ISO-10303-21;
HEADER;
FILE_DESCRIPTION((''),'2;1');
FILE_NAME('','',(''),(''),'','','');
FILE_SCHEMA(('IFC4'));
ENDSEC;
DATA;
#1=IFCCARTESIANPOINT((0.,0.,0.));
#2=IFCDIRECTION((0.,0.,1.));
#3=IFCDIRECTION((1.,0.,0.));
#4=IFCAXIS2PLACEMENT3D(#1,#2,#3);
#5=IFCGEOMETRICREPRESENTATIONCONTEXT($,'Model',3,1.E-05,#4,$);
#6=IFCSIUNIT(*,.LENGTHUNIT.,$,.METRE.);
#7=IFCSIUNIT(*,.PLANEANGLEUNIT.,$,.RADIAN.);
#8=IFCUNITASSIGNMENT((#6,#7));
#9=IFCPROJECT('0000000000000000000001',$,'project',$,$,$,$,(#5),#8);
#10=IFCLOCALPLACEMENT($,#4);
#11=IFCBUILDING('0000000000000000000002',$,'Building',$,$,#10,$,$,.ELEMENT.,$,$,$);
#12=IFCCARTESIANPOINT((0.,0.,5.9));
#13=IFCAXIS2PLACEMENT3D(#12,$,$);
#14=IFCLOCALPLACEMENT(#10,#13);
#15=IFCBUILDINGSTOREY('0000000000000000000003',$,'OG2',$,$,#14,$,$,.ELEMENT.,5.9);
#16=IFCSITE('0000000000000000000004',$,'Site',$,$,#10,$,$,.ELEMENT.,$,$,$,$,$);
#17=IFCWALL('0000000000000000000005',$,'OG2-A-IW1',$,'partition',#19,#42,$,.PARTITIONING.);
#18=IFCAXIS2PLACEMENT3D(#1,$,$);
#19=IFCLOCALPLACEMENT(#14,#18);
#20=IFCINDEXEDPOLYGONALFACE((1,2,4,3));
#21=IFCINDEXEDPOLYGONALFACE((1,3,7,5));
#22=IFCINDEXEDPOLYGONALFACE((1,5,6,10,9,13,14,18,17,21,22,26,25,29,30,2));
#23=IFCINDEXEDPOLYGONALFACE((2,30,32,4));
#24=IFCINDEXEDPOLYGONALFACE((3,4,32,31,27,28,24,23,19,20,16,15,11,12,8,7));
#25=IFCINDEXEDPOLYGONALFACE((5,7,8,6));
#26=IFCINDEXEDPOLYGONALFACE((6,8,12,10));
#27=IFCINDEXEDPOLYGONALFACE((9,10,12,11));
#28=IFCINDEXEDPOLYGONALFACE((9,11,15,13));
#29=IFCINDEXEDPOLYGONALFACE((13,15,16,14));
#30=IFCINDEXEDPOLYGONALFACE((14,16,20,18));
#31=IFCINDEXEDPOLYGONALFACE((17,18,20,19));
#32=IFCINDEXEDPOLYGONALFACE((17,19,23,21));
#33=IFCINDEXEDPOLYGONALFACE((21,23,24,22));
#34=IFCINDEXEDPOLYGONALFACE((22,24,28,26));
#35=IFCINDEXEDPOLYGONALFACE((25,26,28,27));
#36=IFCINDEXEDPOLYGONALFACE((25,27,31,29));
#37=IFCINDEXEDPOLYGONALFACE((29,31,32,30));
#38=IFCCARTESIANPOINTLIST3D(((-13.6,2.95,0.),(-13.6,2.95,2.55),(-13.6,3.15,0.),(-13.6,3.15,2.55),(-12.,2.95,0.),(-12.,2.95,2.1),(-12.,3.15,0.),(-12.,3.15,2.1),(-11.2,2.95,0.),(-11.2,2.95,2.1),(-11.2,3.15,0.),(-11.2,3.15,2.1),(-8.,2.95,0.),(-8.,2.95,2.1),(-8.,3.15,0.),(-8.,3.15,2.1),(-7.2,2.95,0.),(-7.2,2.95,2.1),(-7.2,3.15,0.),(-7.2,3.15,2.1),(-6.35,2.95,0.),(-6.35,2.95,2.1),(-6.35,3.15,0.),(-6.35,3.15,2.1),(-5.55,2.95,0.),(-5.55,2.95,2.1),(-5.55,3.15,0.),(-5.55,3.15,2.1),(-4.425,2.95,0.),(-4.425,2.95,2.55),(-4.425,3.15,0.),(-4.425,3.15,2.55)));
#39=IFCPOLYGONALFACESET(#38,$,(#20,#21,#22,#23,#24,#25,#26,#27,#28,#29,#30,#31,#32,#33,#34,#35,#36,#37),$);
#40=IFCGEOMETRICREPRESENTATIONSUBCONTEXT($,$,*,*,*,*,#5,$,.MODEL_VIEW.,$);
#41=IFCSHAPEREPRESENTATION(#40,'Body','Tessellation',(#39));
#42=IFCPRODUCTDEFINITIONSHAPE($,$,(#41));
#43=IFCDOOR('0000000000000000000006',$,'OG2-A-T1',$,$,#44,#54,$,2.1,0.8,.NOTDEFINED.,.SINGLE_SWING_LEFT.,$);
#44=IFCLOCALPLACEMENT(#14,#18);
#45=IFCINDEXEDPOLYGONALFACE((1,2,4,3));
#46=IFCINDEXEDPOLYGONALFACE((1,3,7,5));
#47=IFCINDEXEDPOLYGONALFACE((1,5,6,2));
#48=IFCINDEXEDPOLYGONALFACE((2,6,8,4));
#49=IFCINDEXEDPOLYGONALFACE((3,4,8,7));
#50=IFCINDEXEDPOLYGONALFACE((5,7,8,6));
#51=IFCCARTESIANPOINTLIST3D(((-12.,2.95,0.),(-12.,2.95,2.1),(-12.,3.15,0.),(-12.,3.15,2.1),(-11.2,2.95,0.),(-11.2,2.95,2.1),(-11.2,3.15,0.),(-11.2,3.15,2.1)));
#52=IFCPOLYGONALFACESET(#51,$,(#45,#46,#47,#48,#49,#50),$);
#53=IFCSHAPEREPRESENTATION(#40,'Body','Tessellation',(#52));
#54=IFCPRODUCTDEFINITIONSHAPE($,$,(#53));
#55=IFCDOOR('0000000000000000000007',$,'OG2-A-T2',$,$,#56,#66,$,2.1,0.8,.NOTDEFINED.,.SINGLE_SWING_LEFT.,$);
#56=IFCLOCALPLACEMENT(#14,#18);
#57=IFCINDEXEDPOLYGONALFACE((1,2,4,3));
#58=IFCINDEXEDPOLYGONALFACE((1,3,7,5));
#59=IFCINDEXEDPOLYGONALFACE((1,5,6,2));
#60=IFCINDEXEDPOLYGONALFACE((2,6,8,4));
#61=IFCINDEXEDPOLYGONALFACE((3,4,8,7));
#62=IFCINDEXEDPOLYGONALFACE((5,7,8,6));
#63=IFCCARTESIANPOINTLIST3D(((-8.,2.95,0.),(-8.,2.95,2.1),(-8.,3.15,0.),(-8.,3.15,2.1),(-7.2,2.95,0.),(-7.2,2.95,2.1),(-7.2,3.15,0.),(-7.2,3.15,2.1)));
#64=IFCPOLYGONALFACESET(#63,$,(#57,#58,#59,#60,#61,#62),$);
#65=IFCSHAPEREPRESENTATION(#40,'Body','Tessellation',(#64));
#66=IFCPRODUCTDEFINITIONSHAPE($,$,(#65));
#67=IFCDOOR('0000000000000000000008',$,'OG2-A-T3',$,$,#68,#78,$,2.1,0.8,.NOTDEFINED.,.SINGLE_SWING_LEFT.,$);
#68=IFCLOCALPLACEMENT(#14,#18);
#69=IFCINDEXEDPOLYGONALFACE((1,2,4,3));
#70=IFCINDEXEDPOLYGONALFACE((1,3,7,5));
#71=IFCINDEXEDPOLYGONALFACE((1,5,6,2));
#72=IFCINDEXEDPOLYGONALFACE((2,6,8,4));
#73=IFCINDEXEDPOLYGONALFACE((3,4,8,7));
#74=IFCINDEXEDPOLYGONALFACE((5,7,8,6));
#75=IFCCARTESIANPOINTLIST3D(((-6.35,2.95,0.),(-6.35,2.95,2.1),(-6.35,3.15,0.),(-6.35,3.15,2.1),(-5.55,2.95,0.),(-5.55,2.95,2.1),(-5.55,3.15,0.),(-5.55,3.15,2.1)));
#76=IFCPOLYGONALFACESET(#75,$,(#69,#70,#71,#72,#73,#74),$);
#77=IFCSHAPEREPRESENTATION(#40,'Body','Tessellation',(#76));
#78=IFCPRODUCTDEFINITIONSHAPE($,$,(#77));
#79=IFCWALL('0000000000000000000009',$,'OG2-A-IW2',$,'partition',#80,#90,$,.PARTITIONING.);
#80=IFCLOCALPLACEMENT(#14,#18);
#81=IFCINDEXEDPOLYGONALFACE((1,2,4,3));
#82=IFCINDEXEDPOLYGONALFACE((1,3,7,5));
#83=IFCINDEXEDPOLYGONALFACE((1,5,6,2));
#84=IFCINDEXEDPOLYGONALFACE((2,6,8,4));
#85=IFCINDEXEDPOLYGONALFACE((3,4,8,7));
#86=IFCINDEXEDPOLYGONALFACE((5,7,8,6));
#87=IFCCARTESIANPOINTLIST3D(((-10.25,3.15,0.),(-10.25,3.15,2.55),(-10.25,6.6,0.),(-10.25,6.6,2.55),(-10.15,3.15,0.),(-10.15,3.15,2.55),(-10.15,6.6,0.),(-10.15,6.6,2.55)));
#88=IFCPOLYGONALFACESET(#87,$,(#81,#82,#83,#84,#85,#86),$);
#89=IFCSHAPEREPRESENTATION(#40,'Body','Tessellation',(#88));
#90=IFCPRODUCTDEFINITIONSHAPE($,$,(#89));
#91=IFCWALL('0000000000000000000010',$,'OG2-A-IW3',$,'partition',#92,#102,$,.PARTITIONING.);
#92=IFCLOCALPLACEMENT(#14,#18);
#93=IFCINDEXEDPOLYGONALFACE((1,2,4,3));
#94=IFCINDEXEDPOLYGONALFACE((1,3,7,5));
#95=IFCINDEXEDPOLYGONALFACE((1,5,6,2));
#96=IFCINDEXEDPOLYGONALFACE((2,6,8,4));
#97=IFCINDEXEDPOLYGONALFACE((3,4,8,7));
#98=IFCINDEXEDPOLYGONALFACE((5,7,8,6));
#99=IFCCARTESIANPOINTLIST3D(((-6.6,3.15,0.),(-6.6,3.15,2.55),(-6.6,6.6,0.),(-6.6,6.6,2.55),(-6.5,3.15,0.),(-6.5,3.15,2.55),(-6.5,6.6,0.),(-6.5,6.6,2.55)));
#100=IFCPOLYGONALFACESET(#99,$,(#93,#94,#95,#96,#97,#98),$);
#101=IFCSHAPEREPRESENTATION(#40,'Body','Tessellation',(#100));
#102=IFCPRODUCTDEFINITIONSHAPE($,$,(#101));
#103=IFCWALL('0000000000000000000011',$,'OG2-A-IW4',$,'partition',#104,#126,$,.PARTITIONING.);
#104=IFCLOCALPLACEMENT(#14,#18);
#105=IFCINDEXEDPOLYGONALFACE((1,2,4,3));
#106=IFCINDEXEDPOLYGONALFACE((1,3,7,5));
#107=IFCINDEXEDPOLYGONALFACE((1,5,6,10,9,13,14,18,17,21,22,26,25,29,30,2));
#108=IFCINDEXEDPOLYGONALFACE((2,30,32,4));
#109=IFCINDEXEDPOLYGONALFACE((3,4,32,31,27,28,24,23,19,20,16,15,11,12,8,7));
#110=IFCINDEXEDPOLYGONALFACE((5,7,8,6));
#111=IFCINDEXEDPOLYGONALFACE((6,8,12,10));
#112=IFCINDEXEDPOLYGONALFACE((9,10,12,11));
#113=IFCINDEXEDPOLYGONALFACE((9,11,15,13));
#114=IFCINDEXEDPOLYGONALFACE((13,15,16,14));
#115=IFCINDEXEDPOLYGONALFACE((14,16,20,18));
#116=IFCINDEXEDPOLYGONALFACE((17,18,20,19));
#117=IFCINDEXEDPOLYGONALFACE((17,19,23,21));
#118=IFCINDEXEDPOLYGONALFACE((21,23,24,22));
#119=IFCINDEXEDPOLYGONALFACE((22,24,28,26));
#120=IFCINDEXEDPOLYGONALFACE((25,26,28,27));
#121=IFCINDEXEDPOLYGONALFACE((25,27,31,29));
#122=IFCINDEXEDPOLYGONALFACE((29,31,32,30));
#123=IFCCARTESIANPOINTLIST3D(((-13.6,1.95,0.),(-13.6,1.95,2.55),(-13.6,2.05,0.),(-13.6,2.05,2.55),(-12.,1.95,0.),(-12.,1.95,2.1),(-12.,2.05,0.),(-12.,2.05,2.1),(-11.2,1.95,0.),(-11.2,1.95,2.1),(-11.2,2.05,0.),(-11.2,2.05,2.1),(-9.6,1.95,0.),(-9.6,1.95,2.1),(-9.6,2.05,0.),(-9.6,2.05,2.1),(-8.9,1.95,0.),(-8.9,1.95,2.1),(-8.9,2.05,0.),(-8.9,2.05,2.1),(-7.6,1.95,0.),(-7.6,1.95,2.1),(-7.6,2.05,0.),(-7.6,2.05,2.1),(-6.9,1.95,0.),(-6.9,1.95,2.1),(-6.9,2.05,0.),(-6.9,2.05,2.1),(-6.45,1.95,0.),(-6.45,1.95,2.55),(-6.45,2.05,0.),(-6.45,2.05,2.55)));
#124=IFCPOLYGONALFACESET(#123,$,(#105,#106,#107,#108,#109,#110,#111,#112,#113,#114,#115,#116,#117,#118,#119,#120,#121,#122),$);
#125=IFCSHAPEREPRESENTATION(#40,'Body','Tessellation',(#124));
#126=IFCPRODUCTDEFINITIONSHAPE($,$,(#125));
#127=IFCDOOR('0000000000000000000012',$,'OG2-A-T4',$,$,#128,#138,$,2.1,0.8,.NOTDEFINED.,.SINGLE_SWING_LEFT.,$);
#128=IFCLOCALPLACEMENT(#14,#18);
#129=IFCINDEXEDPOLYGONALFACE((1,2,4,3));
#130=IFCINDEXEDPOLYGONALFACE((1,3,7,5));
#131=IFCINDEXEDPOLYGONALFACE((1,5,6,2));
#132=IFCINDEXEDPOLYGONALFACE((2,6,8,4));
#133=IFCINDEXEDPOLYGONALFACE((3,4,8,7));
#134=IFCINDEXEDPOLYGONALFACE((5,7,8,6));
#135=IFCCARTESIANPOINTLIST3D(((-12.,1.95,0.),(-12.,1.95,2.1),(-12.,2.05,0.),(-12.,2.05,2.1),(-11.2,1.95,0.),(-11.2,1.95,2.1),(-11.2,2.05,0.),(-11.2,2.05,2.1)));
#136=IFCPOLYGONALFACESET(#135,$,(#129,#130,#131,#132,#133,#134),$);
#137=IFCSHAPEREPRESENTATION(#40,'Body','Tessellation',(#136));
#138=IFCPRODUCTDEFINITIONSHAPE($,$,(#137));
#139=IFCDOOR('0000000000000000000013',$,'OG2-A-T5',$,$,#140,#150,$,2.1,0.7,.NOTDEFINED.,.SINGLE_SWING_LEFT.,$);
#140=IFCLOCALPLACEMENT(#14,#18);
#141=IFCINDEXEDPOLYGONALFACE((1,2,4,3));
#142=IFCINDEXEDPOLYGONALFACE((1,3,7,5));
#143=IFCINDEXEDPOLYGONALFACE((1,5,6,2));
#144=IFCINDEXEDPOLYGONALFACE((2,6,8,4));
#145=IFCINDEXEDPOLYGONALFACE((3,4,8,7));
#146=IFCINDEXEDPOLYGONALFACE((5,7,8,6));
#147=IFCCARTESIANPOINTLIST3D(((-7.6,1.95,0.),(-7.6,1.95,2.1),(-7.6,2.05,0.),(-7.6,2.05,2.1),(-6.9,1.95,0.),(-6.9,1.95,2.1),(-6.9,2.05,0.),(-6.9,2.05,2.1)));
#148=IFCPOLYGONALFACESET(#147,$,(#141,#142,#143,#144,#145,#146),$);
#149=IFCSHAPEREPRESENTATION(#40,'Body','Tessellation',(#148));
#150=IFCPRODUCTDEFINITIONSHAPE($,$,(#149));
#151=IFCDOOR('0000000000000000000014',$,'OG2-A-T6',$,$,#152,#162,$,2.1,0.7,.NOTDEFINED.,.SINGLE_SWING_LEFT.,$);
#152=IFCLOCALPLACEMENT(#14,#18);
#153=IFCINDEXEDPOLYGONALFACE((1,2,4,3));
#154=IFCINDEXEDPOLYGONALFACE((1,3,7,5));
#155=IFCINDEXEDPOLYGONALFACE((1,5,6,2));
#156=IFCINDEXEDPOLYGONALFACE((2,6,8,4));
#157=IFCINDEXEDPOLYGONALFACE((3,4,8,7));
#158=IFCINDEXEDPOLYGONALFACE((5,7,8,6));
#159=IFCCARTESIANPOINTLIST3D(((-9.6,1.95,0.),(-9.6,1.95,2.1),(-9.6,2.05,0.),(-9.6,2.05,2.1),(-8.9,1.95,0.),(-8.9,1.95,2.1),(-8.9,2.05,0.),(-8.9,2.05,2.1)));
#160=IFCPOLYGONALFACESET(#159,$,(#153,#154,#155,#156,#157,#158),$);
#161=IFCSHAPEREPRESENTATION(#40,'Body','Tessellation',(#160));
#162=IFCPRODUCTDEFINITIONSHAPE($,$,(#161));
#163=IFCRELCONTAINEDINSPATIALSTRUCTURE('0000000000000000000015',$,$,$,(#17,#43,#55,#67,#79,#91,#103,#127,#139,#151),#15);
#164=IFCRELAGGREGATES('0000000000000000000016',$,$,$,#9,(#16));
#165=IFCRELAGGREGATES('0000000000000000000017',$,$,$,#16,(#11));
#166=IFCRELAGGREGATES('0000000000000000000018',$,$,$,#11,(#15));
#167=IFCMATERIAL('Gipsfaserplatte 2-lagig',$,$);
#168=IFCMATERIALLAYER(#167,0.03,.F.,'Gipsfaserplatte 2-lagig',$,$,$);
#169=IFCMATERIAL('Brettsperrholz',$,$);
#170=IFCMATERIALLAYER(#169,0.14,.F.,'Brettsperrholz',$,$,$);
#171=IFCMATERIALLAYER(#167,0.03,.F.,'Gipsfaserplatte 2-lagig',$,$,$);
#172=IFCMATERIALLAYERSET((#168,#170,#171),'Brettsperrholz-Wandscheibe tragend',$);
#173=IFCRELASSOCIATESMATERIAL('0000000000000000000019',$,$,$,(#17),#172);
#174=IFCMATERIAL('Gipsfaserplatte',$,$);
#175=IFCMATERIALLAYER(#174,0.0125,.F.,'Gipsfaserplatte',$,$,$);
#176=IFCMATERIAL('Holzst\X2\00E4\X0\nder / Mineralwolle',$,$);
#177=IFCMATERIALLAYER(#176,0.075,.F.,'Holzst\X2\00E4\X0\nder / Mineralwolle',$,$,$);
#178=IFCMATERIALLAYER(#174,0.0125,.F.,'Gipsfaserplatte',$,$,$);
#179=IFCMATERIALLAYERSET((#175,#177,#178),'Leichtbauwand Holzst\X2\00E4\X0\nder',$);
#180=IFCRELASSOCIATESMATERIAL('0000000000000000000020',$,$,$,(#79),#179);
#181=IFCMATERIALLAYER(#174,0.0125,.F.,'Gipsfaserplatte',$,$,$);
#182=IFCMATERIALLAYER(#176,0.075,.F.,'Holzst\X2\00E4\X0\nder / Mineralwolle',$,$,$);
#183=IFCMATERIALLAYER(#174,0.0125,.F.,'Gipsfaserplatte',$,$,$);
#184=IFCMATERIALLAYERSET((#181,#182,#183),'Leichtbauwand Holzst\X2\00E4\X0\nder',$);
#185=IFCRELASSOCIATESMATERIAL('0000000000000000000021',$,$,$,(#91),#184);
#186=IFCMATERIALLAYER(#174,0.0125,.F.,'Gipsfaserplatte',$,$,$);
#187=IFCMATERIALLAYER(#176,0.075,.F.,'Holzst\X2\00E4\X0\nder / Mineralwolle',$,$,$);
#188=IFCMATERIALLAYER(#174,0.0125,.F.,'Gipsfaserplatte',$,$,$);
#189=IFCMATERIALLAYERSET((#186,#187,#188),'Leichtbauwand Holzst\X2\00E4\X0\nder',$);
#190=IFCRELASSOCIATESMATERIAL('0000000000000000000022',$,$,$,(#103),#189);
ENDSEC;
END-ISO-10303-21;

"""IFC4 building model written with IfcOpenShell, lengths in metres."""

from ifc_helpers import new_model, si_unit, frame, frame_2d, origin, origin_with_axes, place, context, subcontext, project, spatial, rectangle, extrude, material, layer, layer_set, element, fill, save


model = new_model("IFC4")

# Units and contexts
model_context = context("Model", 3, precision=1e-05, world=origin_with_axes())
sub_context = subcontext(model_context, None, None, "MODEL_VIEW")
ifc_project = project(units=[si_unit("LENGTHUNIT", "METRE"), si_unit("PLANEANGLEUNIT", "RADIAN")], contexts=[model_context])

# Site, building, storey
placement = place(None, origin_with_axes())
site = spatial("IfcSite", under=ifc_project, at=placement, Name="Site", CompositionType="ELEMENT")
building = spatial("IfcBuilding", under=site, at=placement, Name="Building", CompositionType="ELEMENT")
storey_placement = place(placement, frame((0.0, 0.0, 5.9)))
storey = spatial("IfcBuildingStorey", under=building, at=storey_placement, Name="OG2", CompositionType="ELEMENT", Elevation=5.9)

# Shared definitions
ifc_material_1 = material(Name="Gipsfaserplatte")

# Wall, openings, doors
ifc_material_2 = material(Name="Gipsfaserplatte 2-lagig")
ifc_layer_1 = layer(ifc_material_2, 0.03, ventilated=False, Name="Gipsfaserplatte 2-lagig")
ifc_material_3 = material(Name="Brettsperrholz")
ifc_layer_2 = layer(ifc_material_3, 0.14, ventilated=False, Name="Brettsperrholz")
ifc_layer_3 = layer(ifc_material_2, 0.03, ventilated=False, Name="Gipsfaserplatte 2-lagig")
ifc_layer_set_1 = layer_set([ifc_layer_1, ifc_layer_2, ifc_layer_3], Name="Brettsperrholz-Wandscheibe tragend")
wall_1_placement = place(storey_placement, frame((-13.6, 3.05, 0.0), z_axis=(0.0, 0.0, 1.0), x_axis=(1.0, 0.0, 0.0)))
wall_1 = element("IfcWall", 1, at=wall_1_placement, inside=storey, material=ifc_layer_set_1, Name="OG2-A-IW1", ObjectType="partition", PredefinedType="PARTITIONING", context=sub_context, shape_type="SweptSolid", body=[
    extrude(rectangle(XDim=9.175, YDim=0.2, at=frame_2d((4.5875, 0.0))), origin(), (0.0, 0.0, 1.0), 2.55),
])
opening_1_placement = place(wall_1_placement, frame((2.0, 0.15, 0.0), z_axis=(0.0, -1.0, 0.0), x_axis=(1.0, 0.0, 0.0)))
opening_1 = element("IfcOpeningElement", 2, at=opening_1_placement, cuts=wall_1, PredefinedType="OPENING", context=sub_context, shape_type="SweptSolid", body=[
    extrude(rectangle(XDim=0.8, YDim=2.1, at=frame_2d((0.0, 1.05))), origin(), (0.0, 0.0, 1.0), 0.3),
])
opening_2_placement = place(wall_1_placement, frame((6.0, 0.15, 0.0), z_axis=(0.0, -1.0, 0.0), x_axis=(1.0, 0.0, 0.0)))
opening_2 = element("IfcOpeningElement", 3, at=opening_2_placement, cuts=wall_1, PredefinedType="OPENING", context=sub_context, shape_type="SweptSolid", body=[
    extrude(rectangle(XDim=0.8, YDim=2.1, at=frame_2d((0.0, 1.05))), origin(), (0.0, 0.0, 1.0), 0.3),
])
opening_3_placement = place(wall_1_placement, frame((7.65, 0.15, 0.0), z_axis=(0.0, -1.0, 0.0), x_axis=(1.0, 0.0, 0.0)))
opening_3 = element("IfcOpeningElement", 4, at=opening_3_placement, cuts=wall_1, PredefinedType="OPENING", context=sub_context, shape_type="SweptSolid", body=[
    extrude(rectangle(XDim=0.8, YDim=2.1, at=frame_2d((0.0, 1.05))), origin(), (0.0, 0.0, 1.0), 0.3),
])
door_1_placement = place(wall_1_placement, frame((2.0, 0.1, 0.0), z_axis=(0.0, -1.0, 0.0), x_axis=(1.0, 0.0, 0.0)))
door_1 = element("IfcDoor", 5, at=door_1_placement, inside=storey, Name="OG2-A-T1", OperationType="SINGLE_SWING_LEFT", OverallHeight=2.1, OverallWidth=0.8, PredefinedType="NOTDEFINED", context=sub_context, shape_type="SweptSolid", body=[
    extrude(rectangle(XDim=0.8, YDim=2.1, at=frame_2d((0.0, 1.05))), origin(), (0.0, 0.0, 1.0), 0.2),
])
fill(opening_1, door_1)
door_2_placement = place(wall_1_placement, frame((6.0, 0.1, 0.0), z_axis=(0.0, -1.0, 0.0), x_axis=(1.0, 0.0, 0.0)))
door_2 = element("IfcDoor", 6, at=door_2_placement, inside=storey, Name="OG2-A-T2", OperationType="SINGLE_SWING_LEFT", OverallHeight=2.1, OverallWidth=0.8, PredefinedType="NOTDEFINED", context=sub_context, shape_type="SweptSolid", body=[
    extrude(rectangle(XDim=0.8, YDim=2.1, at=frame_2d((0.0, 1.05))), origin(), (0.0, 0.0, 1.0), 0.2),
])
fill(opening_2, door_2)
door_3_placement = place(wall_1_placement, frame((7.65, 0.1, 0.0), z_axis=(0.0, -1.0, 0.0), x_axis=(1.0, 0.0, 0.0)))
door_3 = element("IfcDoor", 7, at=door_3_placement, inside=storey, Name="OG2-A-T3", OperationType="SINGLE_SWING_LEFT", OverallHeight=2.1, OverallWidth=0.8, PredefinedType="NOTDEFINED", context=sub_context, shape_type="SweptSolid", body=[
    extrude(rectangle(XDim=0.8, YDim=2.1, at=frame_2d((0.0, 1.05))), origin(), (0.0, 0.0, 1.0), 0.2),
])
fill(opening_3, door_3)

# Walls
ifc_layer_4 = layer(ifc_material_1, 0.0125, ventilated=False, Name="Gipsfaserplatte")
ifc_material_4 = material(Name="Holzständer / Mineralwolle")
ifc_layer_5 = layer(ifc_material_4, 0.075, ventilated=False, Name="Holzständer / Mineralwolle")
ifc_layer_6 = layer(ifc_material_1, 0.0125, ventilated=False, Name="Gipsfaserplatte")
ifc_layer_set_2 = layer_set([ifc_layer_4, ifc_layer_5, ifc_layer_6], Name="Leichtbauwand Holzständer")
wall_2_placement = place(storey_placement, frame((-10.2, 3.15, 0.0), z_axis=(0.0, 0.0, 1.0), x_axis=(0.0, 1.0, 0.0)))
element("IfcWall", 8, at=wall_2_placement, inside=storey, material=ifc_layer_set_2, Name="OG2-A-IW2", ObjectType="partition", PredefinedType="PARTITIONING", context=sub_context, shape_type="SweptSolid", body=[
    extrude(rectangle(XDim=3.45, YDim=0.1, at=frame_2d((1.725, 0.0))), origin(), (0.0, 0.0, 1.0), 2.55),
])
ifc_layer_7 = layer(ifc_material_1, 0.0125, ventilated=False, Name="Gipsfaserplatte")
ifc_layer_8 = layer(ifc_material_4, 0.075, ventilated=False, Name="Holzständer / Mineralwolle")
ifc_layer_9 = layer(ifc_material_1, 0.0125, ventilated=False, Name="Gipsfaserplatte")
ifc_layer_set_3 = layer_set([ifc_layer_7, ifc_layer_8, ifc_layer_9], Name="Leichtbauwand Holzständer")
wall_3_placement = place(storey_placement, frame((-6.55, 3.15, 0.0), z_axis=(0.0, 0.0, 1.0), x_axis=(0.0, 1.0, 0.0)))
element("IfcWall", 9, at=wall_3_placement, inside=storey, material=ifc_layer_set_3, Name="OG2-A-IW3", ObjectType="partition", PredefinedType="PARTITIONING", context=sub_context, shape_type="SweptSolid", body=[
    extrude(rectangle(XDim=3.45, YDim=0.1, at=frame_2d((1.725, 0.0))), origin(), (0.0, 0.0, 1.0), 2.55),
])

# Wall, openings, doors
ifc_layer_10 = layer(ifc_material_1, 0.0125, ventilated=False, Name="Gipsfaserplatte")
ifc_layer_11 = layer(ifc_material_4, 0.075, ventilated=False, Name="Holzständer / Mineralwolle")
ifc_layer_12 = layer(ifc_material_1, 0.0125, ventilated=False, Name="Gipsfaserplatte")
ifc_layer_set_4 = layer_set([ifc_layer_10, ifc_layer_11, ifc_layer_12], Name="Leichtbauwand Holzständer")
wall_4_placement = place(storey_placement, frame((-13.6, 2.0, 0.0), z_axis=(0.0, 0.0, 1.0), x_axis=(1.0, 0.0, 0.0)))
wall_4 = element("IfcWall", 10, at=wall_4_placement, inside=storey, material=ifc_layer_set_4, Name="OG2-A-IW4", ObjectType="partition", PredefinedType="PARTITIONING", context=sub_context, shape_type="SweptSolid", body=[
    extrude(rectangle(XDim=7.15, YDim=0.1, at=frame_2d((3.575, 0.0))), origin(), (0.0, 0.0, 1.0), 2.55),
])
opening_4_placement = place(wall_4_placement, frame((2.0, 0.1, 0.0), z_axis=(0.0, -1.0, 0.0), x_axis=(1.0, 0.0, 0.0)))
opening_4 = element("IfcOpeningElement", 11, at=opening_4_placement, cuts=wall_4, PredefinedType="OPENING", context=sub_context, shape_type="SweptSolid", body=[
    extrude(rectangle(XDim=0.8, YDim=2.1, at=frame_2d((0.0, 1.05))), origin(), (0.0, 0.0, 1.0), 0.2),
])
opening_5_placement = place(wall_4_placement, frame((6.35, 0.1, 0.0), z_axis=(0.0, -1.0, 0.0), x_axis=(1.0, 0.0, 0.0)))
opening_5 = element("IfcOpeningElement", 12, at=opening_5_placement, cuts=wall_4, PredefinedType="OPENING", context=sub_context, shape_type="SweptSolid", body=[
    extrude(rectangle(XDim=0.7, YDim=2.1, at=frame_2d((0.0, 1.05))), origin(), (0.0, 0.0, 1.0), 0.2),
])
opening_6_placement = place(wall_4_placement, frame((4.35, 0.1, 0.0), z_axis=(0.0, -1.0, 0.0), x_axis=(1.0, 0.0, 0.0)))
opening_6 = element("IfcOpeningElement", 13, at=opening_6_placement, cuts=wall_4, PredefinedType="OPENING", context=sub_context, shape_type="SweptSolid", body=[
    extrude(rectangle(XDim=0.7, YDim=2.1, at=frame_2d((0.0, 1.05))), origin(), (0.0, 0.0, 1.0), 0.2),
])
door_4_placement = place(wall_4_placement, frame((2.0, 0.05, 0.0), z_axis=(0.0, -1.0, 0.0), x_axis=(1.0, 0.0, 0.0)))
door_4 = element("IfcDoor", 14, at=door_4_placement, inside=storey, Name="OG2-A-T4", OperationType="SINGLE_SWING_LEFT", OverallHeight=2.1, OverallWidth=0.8, PredefinedType="NOTDEFINED", context=sub_context, shape_type="SweptSolid", body=[
    extrude(rectangle(XDim=0.8, YDim=2.1, at=frame_2d((0.0, 1.05))), origin(), (0.0, 0.0, 1.0), 0.1),
])
fill(opening_4, door_4)
door_5_placement = place(wall_4_placement, frame((6.35, 0.05, 0.0), z_axis=(0.0, -1.0, 0.0), x_axis=(1.0, 0.0, 0.0)))
door_5 = element("IfcDoor", 15, at=door_5_placement, inside=storey, Name="OG2-A-T5", OperationType="SINGLE_SWING_LEFT", OverallHeight=2.1, OverallWidth=0.7, PredefinedType="NOTDEFINED", context=sub_context, shape_type="SweptSolid", body=[
    extrude(rectangle(XDim=0.7, YDim=2.1, at=frame_2d((0.0, 1.05))), origin(), (0.0, 0.0, 1.0), 0.1),
])
fill(opening_5, door_5)
door_6_placement = place(wall_4_placement, frame((4.35, 0.05, 0.0), z_axis=(0.0, -1.0, 0.0), x_axis=(1.0, 0.0, 0.0)))
door_6 = element("IfcDoor", 16, at=door_6_placement, inside=storey, Name="OG2-A-T6", OperationType="SINGLE_SWING_LEFT", OverallHeight=2.1, OverallWidth=0.7, PredefinedType="NOTDEFINED", context=sub_context, shape_type="SweptSolid", body=[
    extrude(rectangle(XDim=0.7, YDim=2.1, at=frame_2d((0.0, 1.05))), origin(), (0.0, 0.0, 1.0), 0.1),
])
fill(opening_6, door_6)

save(model, "model.ifc")
